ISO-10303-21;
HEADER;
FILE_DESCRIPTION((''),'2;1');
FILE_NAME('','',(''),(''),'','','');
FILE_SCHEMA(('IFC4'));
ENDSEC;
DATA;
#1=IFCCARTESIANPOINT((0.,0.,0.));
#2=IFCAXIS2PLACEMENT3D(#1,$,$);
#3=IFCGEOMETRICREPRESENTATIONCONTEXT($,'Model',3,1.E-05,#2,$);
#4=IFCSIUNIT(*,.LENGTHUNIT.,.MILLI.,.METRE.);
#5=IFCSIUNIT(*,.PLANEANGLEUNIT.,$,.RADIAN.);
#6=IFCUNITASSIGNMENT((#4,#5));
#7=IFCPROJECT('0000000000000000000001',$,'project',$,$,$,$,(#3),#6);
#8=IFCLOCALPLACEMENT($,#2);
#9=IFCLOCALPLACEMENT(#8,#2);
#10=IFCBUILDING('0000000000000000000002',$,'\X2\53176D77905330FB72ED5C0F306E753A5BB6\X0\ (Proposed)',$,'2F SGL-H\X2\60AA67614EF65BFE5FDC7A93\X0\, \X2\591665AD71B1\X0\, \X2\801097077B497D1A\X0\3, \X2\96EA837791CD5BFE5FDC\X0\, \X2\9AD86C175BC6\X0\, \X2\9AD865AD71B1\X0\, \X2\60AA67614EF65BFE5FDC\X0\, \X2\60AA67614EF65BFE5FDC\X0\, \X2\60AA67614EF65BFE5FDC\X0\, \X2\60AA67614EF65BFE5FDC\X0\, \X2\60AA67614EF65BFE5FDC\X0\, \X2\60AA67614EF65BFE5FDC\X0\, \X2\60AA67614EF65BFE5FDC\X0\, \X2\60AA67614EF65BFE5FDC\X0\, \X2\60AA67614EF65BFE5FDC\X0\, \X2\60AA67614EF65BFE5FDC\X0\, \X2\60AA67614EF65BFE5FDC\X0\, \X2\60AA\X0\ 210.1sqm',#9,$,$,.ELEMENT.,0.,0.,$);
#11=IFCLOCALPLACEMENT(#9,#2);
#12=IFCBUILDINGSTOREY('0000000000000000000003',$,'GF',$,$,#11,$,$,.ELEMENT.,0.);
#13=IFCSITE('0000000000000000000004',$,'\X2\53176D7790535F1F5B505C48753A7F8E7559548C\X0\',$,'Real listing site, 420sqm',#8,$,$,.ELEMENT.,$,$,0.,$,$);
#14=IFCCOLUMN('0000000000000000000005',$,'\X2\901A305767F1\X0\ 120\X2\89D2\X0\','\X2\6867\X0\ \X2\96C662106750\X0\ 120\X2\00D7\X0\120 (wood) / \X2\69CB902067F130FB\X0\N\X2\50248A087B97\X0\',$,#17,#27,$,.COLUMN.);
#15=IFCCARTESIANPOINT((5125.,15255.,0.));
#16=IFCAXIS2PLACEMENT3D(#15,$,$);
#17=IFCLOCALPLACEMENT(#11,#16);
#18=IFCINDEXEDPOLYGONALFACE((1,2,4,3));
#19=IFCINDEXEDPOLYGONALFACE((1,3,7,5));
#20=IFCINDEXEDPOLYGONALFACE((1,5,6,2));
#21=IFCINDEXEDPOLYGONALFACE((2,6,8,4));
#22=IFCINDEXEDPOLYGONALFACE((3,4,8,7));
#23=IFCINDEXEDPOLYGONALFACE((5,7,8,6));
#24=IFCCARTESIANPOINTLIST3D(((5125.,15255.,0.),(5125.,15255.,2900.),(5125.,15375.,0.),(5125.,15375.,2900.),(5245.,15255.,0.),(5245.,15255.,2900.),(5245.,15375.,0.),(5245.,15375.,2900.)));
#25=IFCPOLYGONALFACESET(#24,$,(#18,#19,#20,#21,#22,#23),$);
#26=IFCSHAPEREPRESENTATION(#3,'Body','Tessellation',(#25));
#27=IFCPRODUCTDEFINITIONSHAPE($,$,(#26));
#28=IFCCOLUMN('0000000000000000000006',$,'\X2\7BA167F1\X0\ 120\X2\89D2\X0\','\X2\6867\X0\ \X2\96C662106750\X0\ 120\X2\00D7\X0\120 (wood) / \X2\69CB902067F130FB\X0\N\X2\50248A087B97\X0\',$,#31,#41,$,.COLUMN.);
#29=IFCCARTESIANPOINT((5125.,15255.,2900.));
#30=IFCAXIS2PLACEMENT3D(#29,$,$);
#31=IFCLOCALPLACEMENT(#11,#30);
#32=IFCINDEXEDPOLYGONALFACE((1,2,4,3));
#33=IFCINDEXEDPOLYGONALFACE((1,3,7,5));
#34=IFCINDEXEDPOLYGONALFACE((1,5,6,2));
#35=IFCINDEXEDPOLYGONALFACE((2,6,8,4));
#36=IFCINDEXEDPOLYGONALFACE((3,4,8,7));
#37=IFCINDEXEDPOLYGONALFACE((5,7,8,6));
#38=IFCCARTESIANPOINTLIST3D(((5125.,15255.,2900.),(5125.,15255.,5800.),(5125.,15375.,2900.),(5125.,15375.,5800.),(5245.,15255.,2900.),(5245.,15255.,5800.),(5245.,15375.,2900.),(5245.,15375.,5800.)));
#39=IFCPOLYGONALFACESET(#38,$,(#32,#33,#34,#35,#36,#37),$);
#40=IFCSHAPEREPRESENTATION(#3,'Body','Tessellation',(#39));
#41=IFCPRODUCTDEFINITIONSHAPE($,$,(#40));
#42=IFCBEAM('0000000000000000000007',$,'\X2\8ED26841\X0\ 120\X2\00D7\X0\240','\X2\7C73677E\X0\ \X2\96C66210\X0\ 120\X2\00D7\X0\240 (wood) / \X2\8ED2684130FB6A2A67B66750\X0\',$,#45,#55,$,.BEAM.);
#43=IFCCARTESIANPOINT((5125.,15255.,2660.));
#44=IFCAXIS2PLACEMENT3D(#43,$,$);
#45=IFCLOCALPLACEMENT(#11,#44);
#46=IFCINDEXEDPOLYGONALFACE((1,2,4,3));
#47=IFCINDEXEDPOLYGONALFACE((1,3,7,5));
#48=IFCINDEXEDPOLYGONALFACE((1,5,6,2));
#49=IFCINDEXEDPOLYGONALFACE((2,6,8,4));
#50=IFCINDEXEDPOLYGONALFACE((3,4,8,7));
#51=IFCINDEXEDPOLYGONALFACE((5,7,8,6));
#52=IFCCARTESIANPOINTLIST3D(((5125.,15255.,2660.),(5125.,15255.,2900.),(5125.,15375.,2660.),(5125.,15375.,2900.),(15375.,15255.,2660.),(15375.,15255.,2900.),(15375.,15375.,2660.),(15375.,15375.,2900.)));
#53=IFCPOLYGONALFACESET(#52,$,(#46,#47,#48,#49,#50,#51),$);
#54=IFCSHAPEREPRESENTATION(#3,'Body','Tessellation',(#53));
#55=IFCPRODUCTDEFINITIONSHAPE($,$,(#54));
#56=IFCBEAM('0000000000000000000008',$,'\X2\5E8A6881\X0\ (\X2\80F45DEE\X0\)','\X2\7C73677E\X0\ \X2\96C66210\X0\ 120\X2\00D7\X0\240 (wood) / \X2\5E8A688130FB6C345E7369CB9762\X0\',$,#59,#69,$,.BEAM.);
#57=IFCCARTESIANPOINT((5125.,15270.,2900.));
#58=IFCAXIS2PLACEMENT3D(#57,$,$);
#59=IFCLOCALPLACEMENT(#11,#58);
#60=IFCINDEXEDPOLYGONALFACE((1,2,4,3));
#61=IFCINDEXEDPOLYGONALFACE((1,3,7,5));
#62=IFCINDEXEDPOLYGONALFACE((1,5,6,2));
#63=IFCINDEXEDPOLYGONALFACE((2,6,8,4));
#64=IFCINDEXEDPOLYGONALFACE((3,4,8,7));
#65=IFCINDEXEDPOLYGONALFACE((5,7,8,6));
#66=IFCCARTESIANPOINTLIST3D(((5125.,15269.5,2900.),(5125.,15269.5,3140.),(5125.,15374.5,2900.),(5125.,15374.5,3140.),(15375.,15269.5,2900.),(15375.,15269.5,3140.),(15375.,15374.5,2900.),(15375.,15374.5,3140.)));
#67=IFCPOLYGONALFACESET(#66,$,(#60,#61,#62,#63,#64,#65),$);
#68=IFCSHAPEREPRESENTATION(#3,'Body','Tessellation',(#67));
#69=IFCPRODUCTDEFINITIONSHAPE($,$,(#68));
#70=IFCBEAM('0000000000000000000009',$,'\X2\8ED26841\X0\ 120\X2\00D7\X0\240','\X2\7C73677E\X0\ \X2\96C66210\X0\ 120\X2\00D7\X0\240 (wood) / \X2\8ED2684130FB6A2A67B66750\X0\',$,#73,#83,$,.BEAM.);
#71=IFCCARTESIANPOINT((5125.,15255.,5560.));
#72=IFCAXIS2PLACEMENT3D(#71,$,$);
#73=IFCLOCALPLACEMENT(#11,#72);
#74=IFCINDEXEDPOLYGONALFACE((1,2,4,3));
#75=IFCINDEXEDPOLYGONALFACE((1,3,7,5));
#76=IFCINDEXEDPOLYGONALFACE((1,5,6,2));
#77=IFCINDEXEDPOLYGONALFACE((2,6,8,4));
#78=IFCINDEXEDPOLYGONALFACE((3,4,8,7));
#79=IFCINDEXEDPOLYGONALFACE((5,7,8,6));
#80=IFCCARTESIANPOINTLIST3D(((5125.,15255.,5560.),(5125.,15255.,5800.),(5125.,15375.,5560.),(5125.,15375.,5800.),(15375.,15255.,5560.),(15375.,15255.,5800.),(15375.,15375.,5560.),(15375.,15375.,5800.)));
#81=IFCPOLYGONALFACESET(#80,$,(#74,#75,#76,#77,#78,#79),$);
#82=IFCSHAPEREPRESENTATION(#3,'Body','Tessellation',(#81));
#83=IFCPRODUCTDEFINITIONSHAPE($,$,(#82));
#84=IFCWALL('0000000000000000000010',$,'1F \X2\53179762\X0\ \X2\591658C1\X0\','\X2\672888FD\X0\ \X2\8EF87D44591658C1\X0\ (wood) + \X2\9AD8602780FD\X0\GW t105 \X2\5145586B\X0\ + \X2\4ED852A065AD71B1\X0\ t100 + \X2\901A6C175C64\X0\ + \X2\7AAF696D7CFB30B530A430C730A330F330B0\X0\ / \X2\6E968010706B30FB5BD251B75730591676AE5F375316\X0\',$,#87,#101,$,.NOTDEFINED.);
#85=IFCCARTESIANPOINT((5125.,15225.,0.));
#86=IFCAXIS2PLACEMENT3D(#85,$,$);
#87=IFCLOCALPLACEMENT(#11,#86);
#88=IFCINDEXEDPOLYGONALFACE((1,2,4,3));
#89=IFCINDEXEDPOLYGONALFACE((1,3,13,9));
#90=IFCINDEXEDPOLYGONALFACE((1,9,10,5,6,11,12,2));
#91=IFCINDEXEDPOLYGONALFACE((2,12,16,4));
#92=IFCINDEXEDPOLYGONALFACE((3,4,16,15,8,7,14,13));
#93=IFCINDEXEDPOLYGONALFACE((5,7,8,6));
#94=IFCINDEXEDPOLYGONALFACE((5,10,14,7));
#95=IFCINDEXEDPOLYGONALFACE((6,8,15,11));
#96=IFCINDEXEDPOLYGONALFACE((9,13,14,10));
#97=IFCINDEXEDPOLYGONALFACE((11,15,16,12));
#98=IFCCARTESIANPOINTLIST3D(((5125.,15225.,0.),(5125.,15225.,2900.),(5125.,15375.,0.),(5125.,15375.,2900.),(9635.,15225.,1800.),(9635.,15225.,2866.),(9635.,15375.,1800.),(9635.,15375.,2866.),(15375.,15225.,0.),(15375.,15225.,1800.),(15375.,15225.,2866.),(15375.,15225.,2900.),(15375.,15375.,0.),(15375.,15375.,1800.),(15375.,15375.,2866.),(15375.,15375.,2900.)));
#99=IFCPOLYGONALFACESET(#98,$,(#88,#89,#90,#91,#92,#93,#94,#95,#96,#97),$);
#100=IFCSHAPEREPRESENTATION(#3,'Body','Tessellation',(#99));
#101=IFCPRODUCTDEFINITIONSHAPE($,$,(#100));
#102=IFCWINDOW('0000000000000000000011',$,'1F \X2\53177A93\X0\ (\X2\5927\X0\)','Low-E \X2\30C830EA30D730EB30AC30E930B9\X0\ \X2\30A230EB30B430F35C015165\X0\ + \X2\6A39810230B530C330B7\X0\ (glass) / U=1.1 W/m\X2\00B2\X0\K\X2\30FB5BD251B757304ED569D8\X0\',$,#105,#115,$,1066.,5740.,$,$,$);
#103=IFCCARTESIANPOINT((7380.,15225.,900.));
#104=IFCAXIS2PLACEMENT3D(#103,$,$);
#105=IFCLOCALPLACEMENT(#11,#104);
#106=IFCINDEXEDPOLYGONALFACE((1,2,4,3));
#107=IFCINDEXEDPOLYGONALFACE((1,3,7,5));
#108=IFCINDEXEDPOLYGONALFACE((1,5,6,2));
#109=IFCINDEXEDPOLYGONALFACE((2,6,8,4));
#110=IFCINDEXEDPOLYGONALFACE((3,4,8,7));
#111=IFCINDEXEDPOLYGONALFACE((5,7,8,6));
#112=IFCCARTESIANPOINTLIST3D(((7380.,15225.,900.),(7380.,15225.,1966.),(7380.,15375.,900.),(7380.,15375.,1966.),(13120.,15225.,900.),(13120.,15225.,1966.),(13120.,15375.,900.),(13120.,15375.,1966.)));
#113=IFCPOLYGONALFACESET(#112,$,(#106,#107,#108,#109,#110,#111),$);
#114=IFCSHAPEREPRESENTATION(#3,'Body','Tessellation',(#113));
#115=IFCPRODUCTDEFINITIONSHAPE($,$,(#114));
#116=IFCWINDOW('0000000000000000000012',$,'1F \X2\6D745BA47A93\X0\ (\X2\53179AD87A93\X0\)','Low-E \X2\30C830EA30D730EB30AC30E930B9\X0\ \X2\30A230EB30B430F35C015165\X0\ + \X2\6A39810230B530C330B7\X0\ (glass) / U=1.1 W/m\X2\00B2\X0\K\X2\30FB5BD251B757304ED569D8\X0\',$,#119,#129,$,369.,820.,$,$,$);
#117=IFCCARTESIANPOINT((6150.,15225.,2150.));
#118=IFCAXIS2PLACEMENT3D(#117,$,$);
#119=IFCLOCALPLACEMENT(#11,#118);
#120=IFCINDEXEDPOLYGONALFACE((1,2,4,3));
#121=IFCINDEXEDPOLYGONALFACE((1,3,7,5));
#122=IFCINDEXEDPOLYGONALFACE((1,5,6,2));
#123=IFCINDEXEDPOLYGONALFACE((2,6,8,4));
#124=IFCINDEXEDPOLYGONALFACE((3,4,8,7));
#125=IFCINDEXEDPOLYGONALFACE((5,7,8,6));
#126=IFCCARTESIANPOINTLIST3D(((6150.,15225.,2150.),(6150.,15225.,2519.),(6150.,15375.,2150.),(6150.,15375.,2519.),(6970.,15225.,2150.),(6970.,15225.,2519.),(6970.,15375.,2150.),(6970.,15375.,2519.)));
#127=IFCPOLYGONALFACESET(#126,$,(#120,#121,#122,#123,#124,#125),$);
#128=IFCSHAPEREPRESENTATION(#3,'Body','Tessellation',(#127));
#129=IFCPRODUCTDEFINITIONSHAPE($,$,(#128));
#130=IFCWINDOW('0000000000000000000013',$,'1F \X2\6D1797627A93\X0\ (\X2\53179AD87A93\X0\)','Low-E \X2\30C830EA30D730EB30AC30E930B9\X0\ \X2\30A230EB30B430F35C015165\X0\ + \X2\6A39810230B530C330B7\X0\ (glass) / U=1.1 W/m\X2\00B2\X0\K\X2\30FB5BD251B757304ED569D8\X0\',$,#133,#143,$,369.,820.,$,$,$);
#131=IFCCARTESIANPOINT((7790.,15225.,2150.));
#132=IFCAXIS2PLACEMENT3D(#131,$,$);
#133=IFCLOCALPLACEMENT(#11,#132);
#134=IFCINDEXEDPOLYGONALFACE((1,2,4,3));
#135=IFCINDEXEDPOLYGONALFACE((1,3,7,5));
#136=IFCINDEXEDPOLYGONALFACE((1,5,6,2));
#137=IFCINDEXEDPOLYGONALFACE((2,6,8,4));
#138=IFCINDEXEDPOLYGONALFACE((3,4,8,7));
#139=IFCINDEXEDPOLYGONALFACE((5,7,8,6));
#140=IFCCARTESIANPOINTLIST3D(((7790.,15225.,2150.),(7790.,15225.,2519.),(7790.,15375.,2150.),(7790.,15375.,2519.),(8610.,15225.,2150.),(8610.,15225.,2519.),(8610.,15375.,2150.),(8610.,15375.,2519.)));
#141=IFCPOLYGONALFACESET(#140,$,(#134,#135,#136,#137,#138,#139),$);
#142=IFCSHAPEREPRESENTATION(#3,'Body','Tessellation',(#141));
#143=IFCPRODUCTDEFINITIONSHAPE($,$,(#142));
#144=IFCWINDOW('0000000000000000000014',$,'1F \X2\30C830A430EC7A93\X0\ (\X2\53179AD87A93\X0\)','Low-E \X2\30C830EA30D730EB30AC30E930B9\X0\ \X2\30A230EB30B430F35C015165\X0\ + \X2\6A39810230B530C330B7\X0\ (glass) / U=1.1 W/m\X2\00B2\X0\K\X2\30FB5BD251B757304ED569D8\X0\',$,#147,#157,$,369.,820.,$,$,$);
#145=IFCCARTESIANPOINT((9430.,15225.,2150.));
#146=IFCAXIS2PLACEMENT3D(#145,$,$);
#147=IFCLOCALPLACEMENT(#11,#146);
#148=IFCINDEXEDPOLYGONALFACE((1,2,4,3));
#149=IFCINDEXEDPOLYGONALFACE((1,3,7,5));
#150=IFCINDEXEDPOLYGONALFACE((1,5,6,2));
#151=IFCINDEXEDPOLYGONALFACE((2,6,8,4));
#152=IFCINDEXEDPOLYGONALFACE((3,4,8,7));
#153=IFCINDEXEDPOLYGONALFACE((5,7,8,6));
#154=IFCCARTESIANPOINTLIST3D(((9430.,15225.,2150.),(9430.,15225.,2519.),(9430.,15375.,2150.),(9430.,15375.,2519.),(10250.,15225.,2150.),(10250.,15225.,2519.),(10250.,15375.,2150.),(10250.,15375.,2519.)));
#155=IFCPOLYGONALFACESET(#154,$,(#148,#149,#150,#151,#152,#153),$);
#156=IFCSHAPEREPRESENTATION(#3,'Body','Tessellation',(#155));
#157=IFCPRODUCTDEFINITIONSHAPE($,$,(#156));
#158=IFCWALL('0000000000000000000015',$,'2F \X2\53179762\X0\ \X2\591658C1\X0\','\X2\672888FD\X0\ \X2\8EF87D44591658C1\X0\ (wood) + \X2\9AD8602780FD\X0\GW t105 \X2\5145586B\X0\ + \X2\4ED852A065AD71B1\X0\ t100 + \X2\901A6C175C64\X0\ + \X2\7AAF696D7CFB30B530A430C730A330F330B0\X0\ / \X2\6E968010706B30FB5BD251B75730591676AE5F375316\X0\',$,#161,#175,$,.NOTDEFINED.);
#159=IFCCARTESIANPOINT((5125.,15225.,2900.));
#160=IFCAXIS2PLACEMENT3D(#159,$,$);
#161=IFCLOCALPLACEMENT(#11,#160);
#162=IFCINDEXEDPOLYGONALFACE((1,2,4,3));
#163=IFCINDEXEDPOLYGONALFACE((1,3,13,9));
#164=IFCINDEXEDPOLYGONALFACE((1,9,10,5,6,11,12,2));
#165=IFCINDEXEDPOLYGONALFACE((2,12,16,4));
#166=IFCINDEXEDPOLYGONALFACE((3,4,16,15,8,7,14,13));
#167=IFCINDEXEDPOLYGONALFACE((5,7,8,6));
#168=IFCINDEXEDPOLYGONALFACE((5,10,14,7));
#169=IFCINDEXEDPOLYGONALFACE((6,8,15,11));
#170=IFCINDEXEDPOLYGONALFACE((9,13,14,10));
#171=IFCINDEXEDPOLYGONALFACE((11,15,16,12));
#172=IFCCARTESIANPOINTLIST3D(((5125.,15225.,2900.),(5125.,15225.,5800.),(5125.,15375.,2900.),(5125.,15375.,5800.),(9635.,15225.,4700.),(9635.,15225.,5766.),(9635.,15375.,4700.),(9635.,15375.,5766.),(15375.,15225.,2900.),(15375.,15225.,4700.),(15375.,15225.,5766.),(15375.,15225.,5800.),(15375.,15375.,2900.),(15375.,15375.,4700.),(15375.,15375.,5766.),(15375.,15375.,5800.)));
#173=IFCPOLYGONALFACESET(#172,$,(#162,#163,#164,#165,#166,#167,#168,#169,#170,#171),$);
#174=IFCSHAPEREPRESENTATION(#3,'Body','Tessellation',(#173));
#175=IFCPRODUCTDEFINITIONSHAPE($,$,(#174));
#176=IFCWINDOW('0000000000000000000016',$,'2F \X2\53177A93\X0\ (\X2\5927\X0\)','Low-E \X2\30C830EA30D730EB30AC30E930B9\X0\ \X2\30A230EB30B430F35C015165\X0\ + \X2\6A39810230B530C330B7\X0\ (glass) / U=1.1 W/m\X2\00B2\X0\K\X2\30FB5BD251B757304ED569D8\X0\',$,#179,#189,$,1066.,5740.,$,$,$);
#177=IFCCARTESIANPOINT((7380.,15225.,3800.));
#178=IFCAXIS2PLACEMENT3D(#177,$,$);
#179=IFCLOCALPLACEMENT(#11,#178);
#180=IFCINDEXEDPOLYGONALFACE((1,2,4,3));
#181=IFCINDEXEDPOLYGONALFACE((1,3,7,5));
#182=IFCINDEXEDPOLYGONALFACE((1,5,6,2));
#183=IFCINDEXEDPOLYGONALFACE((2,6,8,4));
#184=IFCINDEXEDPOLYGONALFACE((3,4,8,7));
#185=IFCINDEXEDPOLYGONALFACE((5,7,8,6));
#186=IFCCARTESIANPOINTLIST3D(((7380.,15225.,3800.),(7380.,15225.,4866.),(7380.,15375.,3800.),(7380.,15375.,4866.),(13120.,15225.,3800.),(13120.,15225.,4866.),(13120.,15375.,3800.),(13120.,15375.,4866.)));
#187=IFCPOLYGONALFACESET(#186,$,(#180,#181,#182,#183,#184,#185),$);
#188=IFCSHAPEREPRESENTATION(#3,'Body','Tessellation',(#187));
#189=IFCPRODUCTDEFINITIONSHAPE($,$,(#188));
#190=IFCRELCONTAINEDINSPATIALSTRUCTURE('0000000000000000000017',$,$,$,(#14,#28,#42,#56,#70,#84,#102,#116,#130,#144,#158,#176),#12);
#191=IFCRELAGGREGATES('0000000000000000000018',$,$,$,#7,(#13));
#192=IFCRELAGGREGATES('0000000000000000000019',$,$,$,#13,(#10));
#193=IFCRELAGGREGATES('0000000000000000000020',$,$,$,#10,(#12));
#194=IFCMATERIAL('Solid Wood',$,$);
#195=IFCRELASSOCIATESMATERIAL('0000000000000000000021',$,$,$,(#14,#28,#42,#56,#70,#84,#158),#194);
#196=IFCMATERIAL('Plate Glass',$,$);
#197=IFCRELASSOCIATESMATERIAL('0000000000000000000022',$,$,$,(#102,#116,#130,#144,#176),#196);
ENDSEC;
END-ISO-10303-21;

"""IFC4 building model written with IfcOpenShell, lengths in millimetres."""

from ifc_helpers import new_model, si_unit, frame, frame_2d, origin, place, context, project, spatial, rectangle, extrude, material, element, fill, save


model = new_model("IFC4")

# Units and contexts
model_context = context("Model", 3, precision=1e-05, world=origin())
ifc_project = project(units=[si_unit("LENGTHUNIT", "METRE", prefix="MILLI"), si_unit("PLANEANGLEUNIT", "RADIAN")], contexts=[model_context])

# Site, building, storey
site_placement = place(None, origin())
site = spatial("IfcSite", under=ifc_project, at=site_placement, Name="北海道弟子屈町美留和", ObjectType="Real listing site, 420sqm", CompositionType="ELEMENT", RefElevation=0.0)
building_placement = place(site_placement, origin())
building = spatial("IfcBuilding", under=site, at=building_placement, Name="北海道・狭小の町家 (Proposed)", ObjectType="2F SGL-H悪条件対応窓, 外断熱, 耐震等級3, 雪荷重対応, 高気密, 高断熱, 悪条件対応, 悪条件対応, 悪条件対応, 悪条件対応, 悪条件対応, 悪条件対応, 悪条件対応, 悪条件対応, 悪条件対応, 悪条件対応, 悪条件対応, 悪 210.1sqm", CompositionType="ELEMENT", ElevationOfRefHeight=0.0, ElevationOfTerrain=0.0)
storey_placement = place(building_placement, origin())
storey = spatial("IfcBuildingStorey", under=building, at=storey_placement, Name="GF", CompositionType="ELEMENT", Elevation=0.0)

# Columns
ifc_material_1 = material(Name="Solid Wood")
column_1_placement = place(storey_placement, frame((5125.0, 15255.0, 0.0)))
element("IfcColumn", 1, at=column_1_placement, inside=storey, material=ifc_material_1, Name="通し柱 120角", Description="桧 集成材 120×120 (wood) / 構造柱・N値計算", PredefinedType="COLUMN", context=model_context, shape_type="SweptSolid", body=[
    extrude(rectangle(XDim=120.0, YDim=120.0, at=frame_2d((60.0, 60.0))), frame((5125.0, 15255.0, 0.0)), (0.0, 0.0, 1.0), 2900.0),
])
column_2_placement = place(storey_placement, frame((5125.0, 15255.0, 2900.0)))
element("IfcColumn", 2, at=column_2_placement, inside=storey, material=ifc_material_1, Name="管柱 120角", Description="桧 集成材 120×120 (wood) / 構造柱・N値計算", PredefinedType="COLUMN", context=model_context, shape_type="SweptSolid", body=[
    extrude(rectangle(XDim=120.0, YDim=120.0, at=frame_2d((60.0, 60.0))), frame((5125.0, 15255.0, 2900.0)), (0.0, 0.0, 1.0), 2900.0),
])

# Beams
beam_1_placement = place(storey_placement, frame((5125.0, 15255.0, 2660.0)))
element("IfcBeam", 3, at=beam_1_placement, inside=storey, material=ifc_material_1, Name="軒桁 120×240", Description="米松 集成 120×240 (wood) / 軒桁・横架材", PredefinedType="BEAM", context=model_context, shape_type="SweptSolid", body=[
    extrude(rectangle(XDim=10250.0, YDim=120.0, at=frame_2d((5125.0, 60.0))), frame((5125.0, 15255.0, 2660.0)), (0.0, 0.0, 1.0), 240.0),
])
beam_2_placement = place(storey_placement, frame((5125.0, 15270.0, 2900.0)))
element("IfcBeam", 4, at=beam_2_placement, inside=storey, material=ifc_material_1, Name="床梁 (胴差)", Description="米松 集成 120×240 (wood) / 床梁・水平構面", PredefinedType="BEAM", context=model_context, shape_type="SweptSolid", body=[
    extrude(rectangle(XDim=10250.0, YDim=105.0, at=frame_2d((5125.0, 52.0))), frame((5125.0, 15270.0, 2900.0)), (0.0, 0.0, 1.0), 240.0),
])
beam_3_placement = place(storey_placement, frame((5125.0, 15255.0, 5560.0)))
element("IfcBeam", 5, at=beam_3_placement, inside=storey, material=ifc_material_1, Name="軒桁 120×240", Description="米松 集成 120×240 (wood) / 軒桁・横架材", PredefinedType="BEAM", context=model_context, shape_type="SweptSolid", body=[
    extrude(rectangle(XDim=10250.0, YDim=120.0, at=frame_2d((5125.0, 60.0))), frame((5125.0, 15255.0, 5560.0)), (0.0, 0.0, 1.0), 240.0),
])

# Wall, openings, windows
wall_1_placement = place(storey_placement, frame((5125.0, 15225.0, 0.0)))
wall_1 = element("IfcWall", 6, at=wall_1_placement, inside=storey, material=ifc_material_1, Name="1F 北面 外壁", Description="木製 軸組外壁 (wood) + 高性能GW t105 充填 + 付加断熱 t100 + 通気層 + 窯業系サイディング / 準耐火・寒冷地外皮強化", PredefinedType="NOTDEFINED", context=model_context, shape_type="SweptSolid", body=[
    extrude(rectangle(XDim=10250.0, YDim=150.0, at=frame_2d((5125.0, 75.0))), frame((5125.0, 15225.0, 0.0)), (0.0, 0.0, 1.0), 2900.0),
])
opening_1_placement = place(storey_placement, frame((7380.0, 15225.0, 900.0)))
opening_1 = element("IfcOpeningElement", 7, at=opening_1_placement, cuts=wall_1, PredefinedType="NOTDEFINED", context=model_context, shape_type="SweptSolid", body=[
    extrude(rectangle(XDim=5740.0, YDim=150.0, at=frame_2d((2870.0, 75.0))), frame((7380.0, 15225.0, 900.0)), (0.0, 0.0, 1.0), 1066.0),
])
opening_2_placement = place(storey_placement, frame((6150.0, 15225.0, 2150.0)))
opening_2 = element("IfcOpeningElement", 8, at=opening_2_placement, cuts=wall_1, PredefinedType="NOTDEFINED", context=model_context, shape_type="SweptSolid", body=[
    extrude(rectangle(XDim=820.0, YDim=150.0, at=frame_2d((410.0, 75.0))), frame((6150.0, 15225.0, 2150.0)), (0.0, 0.0, 1.0), 369.0),
])
opening_3_placement = place(storey_placement, frame((7790.0, 15225.0, 2150.0)))
opening_3 = element("IfcOpeningElement", 9, at=opening_3_placement, cuts=wall_1, PredefinedType="NOTDEFINED", context=model_context, shape_type="SweptSolid", body=[
    extrude(rectangle(XDim=820.0, YDim=150.0, at=frame_2d((410.0, 75.0))), frame((7790.0, 15225.0, 2150.0)), (0.0, 0.0, 1.0), 369.0),
])
opening_4_placement = place(storey_placement, frame((9430.0, 15225.0, 2150.0)))
opening_4 = element("IfcOpeningElement", 10, at=opening_4_placement, cuts=wall_1, PredefinedType="NOTDEFINED", context=model_context, shape_type="SweptSolid", body=[
    extrude(rectangle(XDim=820.0, YDim=150.0, at=frame_2d((410.0, 75.0))), frame((9430.0, 15225.0, 2150.0)), (0.0, 0.0, 1.0), 369.0),
])
ifc_material_2 = material(Name="Plate Glass")
window_1_placement = place(storey_placement, frame((7380.0, 15225.0, 900.0)))
window_1 = element("IfcWindow", 11, at=window_1_placement, inside=storey, material=ifc_material_2, Name="1F 北窓 (大)", Description="Low-E トリプルガラス アルゴン封入 + 樹脂サッシ (glass) / U=1.1 W/m²K・寒冷地仕様", OverallHeight=1066.0, OverallWidth=5740.0, context=model_context, shape_type="SweptSolid", body=[
    extrude(rectangle(XDim=5740.0, YDim=150.0, at=frame_2d((2870.0, 75.0))), frame((7380.0, 15225.0, 900.0)), (0.0, 0.0, 1.0), 1066.0),
])
fill(opening_1, window_1)
window_2_placement = place(storey_placement, frame((6150.0, 15225.0, 2150.0)))
window_2 = element("IfcWindow", 12, at=window_2_placement, inside=storey, material=ifc_material_2, Name="1F 浴室窓 (北高窓)", Description="Low-E トリプルガラス アルゴン封入 + 樹脂サッシ (glass) / U=1.1 W/m²K・寒冷地仕様", OverallHeight=369.0, OverallWidth=820.0, context=model_context, shape_type="SweptSolid", body=[
    extrude(rectangle(XDim=820.0, YDim=150.0, at=frame_2d((410.0, 75.0))), frame((6150.0, 15225.0, 2150.0)), (0.0, 0.0, 1.0), 369.0),
])
fill(opening_2, window_2)
window_3_placement = place(storey_placement, frame((7790.0, 15225.0, 2150.0)))
window_3 = element("IfcWindow", 13, at=window_3_placement, inside=storey, material=ifc_material_2, Name="1F 洗面窓 (北高窓)", Description="Low-E トリプルガラス アルゴン封入 + 樹脂サッシ (glass) / U=1.1 W/m²K・寒冷地仕様", OverallHeight=369.0, OverallWidth=820.0, context=model_context, shape_type="SweptSolid", body=[
    extrude(rectangle(XDim=820.0, YDim=150.0, at=frame_2d((410.0, 75.0))), frame((7790.0, 15225.0, 2150.0)), (0.0, 0.0, 1.0), 369.0),
])
fill(opening_3, window_3)
window_4_placement = place(storey_placement, frame((9430.0, 15225.0, 2150.0)))
window_4 = element("IfcWindow", 14, at=window_4_placement, inside=storey, material=ifc_material_2, Name="1F トイレ窓 (北高窓)", Description="Low-E トリプルガラス アルゴン封入 + 樹脂サッシ (glass) / U=1.1 W/m²K・寒冷地仕様", OverallHeight=369.0, OverallWidth=820.0, context=model_context, shape_type="SweptSolid", body=[
    extrude(rectangle(XDim=820.0, YDim=150.0, at=frame_2d((410.0, 75.0))), frame((9430.0, 15225.0, 2150.0)), (0.0, 0.0, 1.0), 369.0),
])
fill(opening_4, window_4)

# Wall, opening, window
wall_2_placement = place(storey_placement, frame((5125.0, 15225.0, 2900.0)))
wall_2 = element("IfcWall", 15, at=wall_2_placement, inside=storey, material=ifc_material_1, Name="2F 北面 外壁", Description="木製 軸組外壁 (wood) + 高性能GW t105 充填 + 付加断熱 t100 + 通気層 + 窯業系サイディング / 準耐火・寒冷地外皮強化", PredefinedType="NOTDEFINED", context=model_context, shape_type="SweptSolid", body=[
    extrude(rectangle(XDim=10250.0, YDim=150.0, at=frame_2d((5125.0, 75.0))), frame((5125.0, 15225.0, 2900.0)), (0.0, 0.0, 1.0), 2900.0),
])
opening_5_placement = place(storey_placement, frame((7380.0, 15225.0, 3800.0)))
opening_5 = element("IfcOpeningElement", 16, at=opening_5_placement, cuts=wall_2, PredefinedType="NOTDEFINED", context=model_context, shape_type="SweptSolid", body=[
    extrude(rectangle(XDim=5740.0, YDim=150.0, at=frame_2d((2870.0, 75.0))), frame((7380.0, 15225.0, 3800.0)), (0.0, 0.0, 1.0), 1066.0),
])
window_5_placement = place(storey_placement, frame((7380.0, 15225.0, 3800.0)))
window_5 = element("IfcWindow", 17, at=window_5_placement, inside=storey, material=ifc_material_2, Name="2F 北窓 (大)", Description="Low-E トリプルガラス アルゴン封入 + 樹脂サッシ (glass) / U=1.1 W/m²K・寒冷地仕様", OverallHeight=1066.0, OverallWidth=5740.0, context=model_context, shape_type="SweptSolid", body=[
    extrude(rectangle(XDim=5740.0, YDim=150.0, at=frame_2d((2870.0, 75.0))), frame((7380.0, 15225.0, 3800.0)), (0.0, 0.0, 1.0), 1066.0),
])
fill(opening_5, window_5)

save(model, "model.ifc")
